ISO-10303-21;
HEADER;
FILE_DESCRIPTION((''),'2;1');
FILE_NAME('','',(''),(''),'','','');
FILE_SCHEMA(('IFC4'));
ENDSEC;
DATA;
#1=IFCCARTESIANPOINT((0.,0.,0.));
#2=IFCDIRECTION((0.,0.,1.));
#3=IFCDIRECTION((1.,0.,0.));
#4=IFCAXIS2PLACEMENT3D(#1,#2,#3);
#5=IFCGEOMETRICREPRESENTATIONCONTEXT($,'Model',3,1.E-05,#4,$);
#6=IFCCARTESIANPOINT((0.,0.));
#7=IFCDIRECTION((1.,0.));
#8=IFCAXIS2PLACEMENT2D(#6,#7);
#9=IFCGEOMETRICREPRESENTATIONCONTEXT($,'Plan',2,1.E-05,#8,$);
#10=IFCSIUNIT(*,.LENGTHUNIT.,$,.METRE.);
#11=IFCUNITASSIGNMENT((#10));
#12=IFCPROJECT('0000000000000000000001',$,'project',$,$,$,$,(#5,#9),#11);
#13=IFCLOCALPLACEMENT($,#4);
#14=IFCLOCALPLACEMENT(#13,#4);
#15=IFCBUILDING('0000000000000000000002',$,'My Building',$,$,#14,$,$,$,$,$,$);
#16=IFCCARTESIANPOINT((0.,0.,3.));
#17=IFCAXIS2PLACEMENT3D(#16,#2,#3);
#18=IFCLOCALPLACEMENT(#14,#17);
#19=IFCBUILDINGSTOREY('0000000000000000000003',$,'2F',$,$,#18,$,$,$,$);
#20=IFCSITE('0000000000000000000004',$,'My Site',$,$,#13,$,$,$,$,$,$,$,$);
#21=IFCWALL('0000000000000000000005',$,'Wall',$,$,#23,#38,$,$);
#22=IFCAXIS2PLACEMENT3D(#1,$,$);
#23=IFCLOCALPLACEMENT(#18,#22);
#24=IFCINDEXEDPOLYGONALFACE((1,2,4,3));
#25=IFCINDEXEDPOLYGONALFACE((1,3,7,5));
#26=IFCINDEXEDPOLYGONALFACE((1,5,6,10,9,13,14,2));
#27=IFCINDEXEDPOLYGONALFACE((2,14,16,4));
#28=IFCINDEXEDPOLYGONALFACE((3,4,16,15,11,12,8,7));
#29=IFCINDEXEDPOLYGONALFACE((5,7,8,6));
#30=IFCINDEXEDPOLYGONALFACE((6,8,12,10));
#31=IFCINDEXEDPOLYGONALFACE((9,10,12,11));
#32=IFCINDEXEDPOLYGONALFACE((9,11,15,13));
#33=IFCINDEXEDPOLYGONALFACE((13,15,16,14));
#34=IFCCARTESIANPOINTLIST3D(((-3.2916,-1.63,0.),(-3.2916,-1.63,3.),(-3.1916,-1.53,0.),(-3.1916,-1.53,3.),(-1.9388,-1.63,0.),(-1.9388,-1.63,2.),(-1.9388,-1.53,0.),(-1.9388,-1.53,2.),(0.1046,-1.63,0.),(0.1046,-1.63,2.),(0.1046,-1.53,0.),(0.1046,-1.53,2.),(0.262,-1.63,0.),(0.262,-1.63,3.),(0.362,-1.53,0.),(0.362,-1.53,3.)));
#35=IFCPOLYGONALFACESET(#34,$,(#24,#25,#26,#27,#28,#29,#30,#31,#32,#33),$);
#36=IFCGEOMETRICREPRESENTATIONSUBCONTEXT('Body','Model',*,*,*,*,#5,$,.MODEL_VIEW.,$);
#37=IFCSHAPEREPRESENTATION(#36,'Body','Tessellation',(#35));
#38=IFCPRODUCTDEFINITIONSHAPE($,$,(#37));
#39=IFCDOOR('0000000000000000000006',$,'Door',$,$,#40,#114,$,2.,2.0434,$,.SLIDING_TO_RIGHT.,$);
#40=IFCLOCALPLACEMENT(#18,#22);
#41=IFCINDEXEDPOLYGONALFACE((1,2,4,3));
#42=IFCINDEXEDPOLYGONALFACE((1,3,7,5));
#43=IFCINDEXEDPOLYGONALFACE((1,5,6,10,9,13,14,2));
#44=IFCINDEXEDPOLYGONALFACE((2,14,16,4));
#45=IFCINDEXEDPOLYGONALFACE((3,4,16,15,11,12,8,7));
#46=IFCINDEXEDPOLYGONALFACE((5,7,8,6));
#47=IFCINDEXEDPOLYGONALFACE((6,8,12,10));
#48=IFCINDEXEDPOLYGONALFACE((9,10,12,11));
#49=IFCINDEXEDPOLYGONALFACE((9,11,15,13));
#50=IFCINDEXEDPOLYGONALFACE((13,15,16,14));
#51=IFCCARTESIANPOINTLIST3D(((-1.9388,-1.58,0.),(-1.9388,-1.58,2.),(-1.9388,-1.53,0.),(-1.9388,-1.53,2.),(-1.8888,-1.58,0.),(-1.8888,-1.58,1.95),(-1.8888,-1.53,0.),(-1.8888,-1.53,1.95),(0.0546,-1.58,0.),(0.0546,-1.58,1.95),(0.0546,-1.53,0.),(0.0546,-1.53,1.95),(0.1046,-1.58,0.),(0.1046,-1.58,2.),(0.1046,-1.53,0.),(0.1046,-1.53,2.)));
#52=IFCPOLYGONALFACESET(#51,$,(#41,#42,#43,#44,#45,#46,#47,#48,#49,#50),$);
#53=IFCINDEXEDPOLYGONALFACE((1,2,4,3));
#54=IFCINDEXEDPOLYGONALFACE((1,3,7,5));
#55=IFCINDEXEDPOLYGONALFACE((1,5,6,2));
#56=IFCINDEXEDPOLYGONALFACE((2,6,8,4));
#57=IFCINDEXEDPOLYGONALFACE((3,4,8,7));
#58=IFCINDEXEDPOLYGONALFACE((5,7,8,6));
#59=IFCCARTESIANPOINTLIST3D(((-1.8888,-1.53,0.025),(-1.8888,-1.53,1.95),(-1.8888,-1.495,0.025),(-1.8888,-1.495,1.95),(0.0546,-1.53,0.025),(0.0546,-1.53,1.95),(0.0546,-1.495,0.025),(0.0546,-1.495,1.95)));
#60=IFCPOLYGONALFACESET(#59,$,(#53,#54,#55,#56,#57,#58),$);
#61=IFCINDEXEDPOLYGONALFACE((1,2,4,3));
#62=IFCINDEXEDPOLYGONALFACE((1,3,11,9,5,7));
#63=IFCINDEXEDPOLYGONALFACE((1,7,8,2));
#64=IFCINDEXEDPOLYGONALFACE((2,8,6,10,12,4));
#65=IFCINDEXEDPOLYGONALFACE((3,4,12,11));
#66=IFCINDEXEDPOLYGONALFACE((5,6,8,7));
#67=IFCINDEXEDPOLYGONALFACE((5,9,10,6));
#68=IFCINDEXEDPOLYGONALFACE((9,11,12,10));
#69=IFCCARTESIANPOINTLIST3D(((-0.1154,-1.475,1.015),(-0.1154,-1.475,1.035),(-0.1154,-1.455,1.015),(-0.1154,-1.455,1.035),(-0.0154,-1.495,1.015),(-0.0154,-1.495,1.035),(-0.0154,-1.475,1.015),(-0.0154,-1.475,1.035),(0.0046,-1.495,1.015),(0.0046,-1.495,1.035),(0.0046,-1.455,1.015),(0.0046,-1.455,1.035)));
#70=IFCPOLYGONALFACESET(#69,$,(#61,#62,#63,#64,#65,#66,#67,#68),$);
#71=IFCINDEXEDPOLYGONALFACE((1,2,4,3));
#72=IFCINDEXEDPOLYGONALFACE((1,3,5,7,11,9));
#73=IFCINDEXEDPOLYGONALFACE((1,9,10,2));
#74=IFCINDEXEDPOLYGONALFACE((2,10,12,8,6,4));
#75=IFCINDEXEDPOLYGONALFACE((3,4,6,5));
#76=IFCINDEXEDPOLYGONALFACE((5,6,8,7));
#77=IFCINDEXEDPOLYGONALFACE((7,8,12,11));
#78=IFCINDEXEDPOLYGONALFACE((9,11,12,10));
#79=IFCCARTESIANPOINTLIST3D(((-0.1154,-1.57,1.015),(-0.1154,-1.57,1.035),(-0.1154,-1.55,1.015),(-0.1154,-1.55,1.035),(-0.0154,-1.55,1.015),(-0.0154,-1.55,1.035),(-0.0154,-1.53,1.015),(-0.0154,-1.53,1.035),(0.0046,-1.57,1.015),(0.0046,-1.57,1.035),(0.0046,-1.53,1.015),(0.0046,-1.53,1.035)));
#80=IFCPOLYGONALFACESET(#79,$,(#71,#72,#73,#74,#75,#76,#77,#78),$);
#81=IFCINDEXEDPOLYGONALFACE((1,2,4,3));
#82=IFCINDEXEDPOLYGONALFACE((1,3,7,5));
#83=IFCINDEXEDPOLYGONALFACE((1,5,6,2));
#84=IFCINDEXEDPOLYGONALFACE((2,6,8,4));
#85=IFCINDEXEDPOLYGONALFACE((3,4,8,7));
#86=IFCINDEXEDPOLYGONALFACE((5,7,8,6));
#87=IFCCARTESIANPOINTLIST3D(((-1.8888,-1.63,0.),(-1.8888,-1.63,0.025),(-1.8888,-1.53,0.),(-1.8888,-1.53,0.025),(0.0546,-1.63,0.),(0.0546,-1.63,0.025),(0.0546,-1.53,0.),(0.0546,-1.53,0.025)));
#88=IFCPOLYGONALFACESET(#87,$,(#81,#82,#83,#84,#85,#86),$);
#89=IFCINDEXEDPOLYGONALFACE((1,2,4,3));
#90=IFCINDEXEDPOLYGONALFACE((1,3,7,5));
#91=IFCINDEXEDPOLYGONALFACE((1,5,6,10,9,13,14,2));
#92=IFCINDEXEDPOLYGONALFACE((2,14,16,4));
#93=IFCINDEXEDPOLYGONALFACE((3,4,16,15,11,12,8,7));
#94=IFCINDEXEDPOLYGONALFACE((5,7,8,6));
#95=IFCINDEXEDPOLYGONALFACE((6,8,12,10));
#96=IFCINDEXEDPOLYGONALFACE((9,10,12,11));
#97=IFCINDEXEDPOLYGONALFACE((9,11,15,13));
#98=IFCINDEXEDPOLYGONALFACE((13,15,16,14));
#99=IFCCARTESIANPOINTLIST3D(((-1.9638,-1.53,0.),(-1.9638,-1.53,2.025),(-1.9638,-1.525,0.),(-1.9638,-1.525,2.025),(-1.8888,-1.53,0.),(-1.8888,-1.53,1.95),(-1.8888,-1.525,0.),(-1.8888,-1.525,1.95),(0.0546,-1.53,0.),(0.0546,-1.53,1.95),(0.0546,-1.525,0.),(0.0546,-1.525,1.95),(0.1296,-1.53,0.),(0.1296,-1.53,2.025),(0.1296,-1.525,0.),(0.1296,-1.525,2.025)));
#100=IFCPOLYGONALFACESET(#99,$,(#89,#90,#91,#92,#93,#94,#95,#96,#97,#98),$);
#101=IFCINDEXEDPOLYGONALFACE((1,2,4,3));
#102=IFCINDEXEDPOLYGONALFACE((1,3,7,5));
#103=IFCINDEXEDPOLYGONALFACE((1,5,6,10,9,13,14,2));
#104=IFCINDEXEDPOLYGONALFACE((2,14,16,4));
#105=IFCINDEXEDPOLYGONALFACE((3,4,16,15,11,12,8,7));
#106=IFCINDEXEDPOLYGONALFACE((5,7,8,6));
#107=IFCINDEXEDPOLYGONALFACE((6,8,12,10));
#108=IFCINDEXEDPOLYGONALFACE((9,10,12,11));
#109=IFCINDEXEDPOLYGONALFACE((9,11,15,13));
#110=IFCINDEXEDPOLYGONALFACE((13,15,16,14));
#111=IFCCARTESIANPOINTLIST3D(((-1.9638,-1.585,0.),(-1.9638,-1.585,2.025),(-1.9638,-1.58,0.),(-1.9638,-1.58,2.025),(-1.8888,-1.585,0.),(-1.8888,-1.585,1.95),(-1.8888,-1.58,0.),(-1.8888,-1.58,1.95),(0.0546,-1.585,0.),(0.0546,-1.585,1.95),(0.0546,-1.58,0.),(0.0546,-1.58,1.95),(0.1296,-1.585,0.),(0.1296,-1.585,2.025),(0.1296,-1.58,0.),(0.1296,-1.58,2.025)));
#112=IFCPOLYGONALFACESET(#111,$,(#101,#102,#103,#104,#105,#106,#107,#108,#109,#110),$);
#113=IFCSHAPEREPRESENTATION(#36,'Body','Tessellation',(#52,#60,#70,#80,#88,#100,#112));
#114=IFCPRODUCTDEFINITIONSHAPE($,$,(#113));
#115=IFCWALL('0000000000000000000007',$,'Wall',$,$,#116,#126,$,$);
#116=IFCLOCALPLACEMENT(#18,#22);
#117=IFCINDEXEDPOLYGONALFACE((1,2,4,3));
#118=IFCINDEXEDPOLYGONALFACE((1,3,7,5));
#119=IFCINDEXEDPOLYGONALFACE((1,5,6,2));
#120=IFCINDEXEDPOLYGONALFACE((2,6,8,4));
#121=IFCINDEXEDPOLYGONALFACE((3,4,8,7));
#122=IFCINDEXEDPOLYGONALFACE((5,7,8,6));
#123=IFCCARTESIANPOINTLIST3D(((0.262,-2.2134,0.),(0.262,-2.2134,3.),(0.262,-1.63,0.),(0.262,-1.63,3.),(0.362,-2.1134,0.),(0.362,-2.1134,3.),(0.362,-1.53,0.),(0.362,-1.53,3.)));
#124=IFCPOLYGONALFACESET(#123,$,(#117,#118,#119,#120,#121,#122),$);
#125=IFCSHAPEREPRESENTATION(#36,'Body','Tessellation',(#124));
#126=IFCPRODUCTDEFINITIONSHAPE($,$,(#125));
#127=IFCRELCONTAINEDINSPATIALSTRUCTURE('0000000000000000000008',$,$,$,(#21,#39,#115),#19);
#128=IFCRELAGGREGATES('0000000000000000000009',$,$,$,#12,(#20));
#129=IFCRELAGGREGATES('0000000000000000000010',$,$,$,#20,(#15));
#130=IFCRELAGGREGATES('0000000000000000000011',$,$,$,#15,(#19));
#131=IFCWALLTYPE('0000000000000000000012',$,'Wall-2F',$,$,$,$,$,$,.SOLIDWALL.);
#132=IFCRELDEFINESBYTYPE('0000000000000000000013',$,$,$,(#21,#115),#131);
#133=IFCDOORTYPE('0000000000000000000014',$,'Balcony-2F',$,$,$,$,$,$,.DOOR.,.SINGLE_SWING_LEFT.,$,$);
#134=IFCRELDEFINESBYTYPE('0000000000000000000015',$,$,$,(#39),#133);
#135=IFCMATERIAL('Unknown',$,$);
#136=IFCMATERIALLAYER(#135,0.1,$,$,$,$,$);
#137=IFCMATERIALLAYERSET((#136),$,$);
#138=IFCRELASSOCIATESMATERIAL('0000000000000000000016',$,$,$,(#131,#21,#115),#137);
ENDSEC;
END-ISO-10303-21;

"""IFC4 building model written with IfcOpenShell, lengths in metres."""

from ifc_helpers import new_model, entity, si_unit, frame, origin_with_axes, origin_2d_with_axis, place, context, subcontext, project, spatial, line, indexed_curve, outline, extrude, shape, source, transform, mapped, material, layer, layer_set, layer_usage, type_object, type_shapes, element, fill, save


model = new_model("IFC4")

# Units and contexts
model_context = context("Model", 3, precision=1e-05, world=origin_with_axes())
plan_context = context("Plan", 2, precision=1e-05, world=origin_2d_with_axis())
body_context_1 = subcontext(model_context, "Body", "Model", "MODEL_VIEW")
body_context_2 = subcontext(plan_context, "Body", "Plan", "PLAN_VIEW")
ifc_project = project(units=[si_unit("LENGTHUNIT", "METRE")], contexts=[model_context, plan_context])

# Site, building, storey
site_placement = place(None, origin_with_axes())
site = spatial("IfcSite", under=ifc_project, at=site_placement, Name="My Site")
building_placement = place(site_placement, origin_with_axes())
building = spatial("IfcBuilding", under=site, at=building_placement, Name="My Building")
storey_placement = place(building_placement, frame((0.0, 0.0, 3.0), z_axis=(0.0, 0.0, 1.0), x_axis=(1.0, 0.0, 0.0)))
storey = spatial("IfcBuildingStorey", under=building, at=storey_placement, Name="2F")

# Shared definitions
ifc_material = material(Name="Unknown")

# Wall, opening, door
ifc_layer = layer(ifc_material, 0.1)
ifc_layer_set = layer_set([ifc_layer])
ifc_layer_usage_1 = layer_usage(ifc_layer_set, "AXIS2", "POSITIVE", 0.0)
wall_type = type_object("IfcWallType", Name="Wall-2F", PredefinedType="SOLIDWALL", material=ifc_layer_set)
wall_1_placement = place(storey_placement, frame((-3.2916, -1.63, 0.0), z_axis=(0.0, 0.0, 1.0), x_axis=(1.0, 0.0, 0.0)))
wall_1 = element("IfcWall", 1, at=wall_1_placement, inside=storey, type_object=wall_type, material=ifc_layer_usage_1, Name="Wall", context=body_context_1, shape_type="SweptSolid", body=[
    extrude(outline(indexed_curve([(0.0, 0.0), (0.1, 0.1), (3.6537, 0.1), (3.5537, 0.0)], segments=[line(1, 2, 3, 4, 1)])), origin_with_axes(), (0.0, 0.0, 1.0), 3.0),
])
shared_shape_1 = source(origin_with_axes(), body_context_1, "Body", "SweptSolid", [
    extrude(outline(indexed_curve([(0.0, 0.0), (2.0434, 0.0), (2.0434, 2.0), (0.0, 2.0)], segments=[line(1, 2, 3, 4, 1)])), frame((0.0, -0.6, 0.0), z_axis=(0.0, -1.0, 0.0), x_axis=(1.0, 0.0, 0.0)), (0.0, 0.0, -1.0), 1.2),
])
opening_1_placement = place(wall_1_placement, frame((3.3963, 0.1, 0.0), z_axis=(0.0, 0.0, 1.0), x_axis=(-1.0, 0.0, 0.0)))
opening_1 = element("IfcOpeningElement", 2, at=opening_1_placement, cuts=wall_1, PredefinedType="OPENING", context=body_context_1, shape_type="MappedRepresentation", body=[
    mapped(shared_shape_1, transform((0.0, 0.0, 0.0), x_axis=(1.0, 0.0, 0.0), y_axis=(0.0, 1.0, 0.0), z_axis=(0.0, 0.0, 1.0), scale=1.0)),
])
door_type_1 = type_object("IfcDoorType", Name="Balcony-2F", OperationType="SINGLE_SWING_LEFT", PredefinedType="DOOR")
shared_shape_2 = source(origin_with_axes(), body_context_1, "Body", "SweptSolid", [
    extrude(outline(indexed_curve([(0.0, 0.0), (0.0, 2.0), (2.0434, 2.0), (2.0434, 0.0), (1.9934, 0.0), (1.9934, 1.95), (0.05, 1.95), (0.05, 0.0)], segments=[line(1, 2, 3, 4, 5, 6, 7, 8, 1)])), frame((0.0, 0.0, 0.0), z_axis=(0.0, -1.0, 0.0), x_axis=(1.0, 0.0, 0.0)), (0.0, 0.0, -1.0), 0.05),
    extrude(outline(indexed_curve([(0.0, 0.0), (1.9434, 0.0), (1.9434, 0.035), (0.0, 0.035)], segments=[line(1, 2, 3, 4, 1)])), frame((0.05, -0.035, 0.025), z_axis=(0.0, 0.0, 1.0), x_axis=(1.0, 0.0, 0.0)), (0.0, 0.0, 1.0), 1.925),
    extrude(outline(indexed_curve([(0.0, 0.0), (0.0, -0.04), (0.12, -0.04), (0.12, -0.02), (0.02, -0.02), (0.02, 0.0)], segments=[line(1, 2, 3, 4, 5, 6, 1)])), frame((0.1, -0.035, 1.015), z_axis=(0.0, 0.0, 1.0), x_axis=(1.0, 0.0, 0.0)), (0.0, 0.0, 1.0), 0.02),
    extrude(outline(indexed_curve([(0.0, 0.0), (0.0, 0.04), (0.12, 0.04), (0.12, 0.02), (0.02, 0.02), (0.02, 0.0)], segments=[line(1, 2, 3, 4, 5, 6, 1)])), frame((0.1, 0.0, 1.015), z_axis=(0.0, 0.0, 1.0), x_axis=(1.0, 0.0, 0.0)), (0.0, 0.0, 1.0), 0.02),
    extrude(outline(indexed_curve([(0.0, 0.0), (1.9434, 0.0), (1.9434, 0.1), (0.0, 0.1)], segments=[line(1, 2, 3, 4, 1)])), frame((0.05, 0.0, 0.0), z_axis=(0.0, 0.0, 1.0), x_axis=(1.0, 0.0, 0.0)), (0.0, 0.0, 1.0), 0.025),
    extrude(outline(indexed_curve([(0.0, 0.0), (0.0, 2.025), (2.0934, 2.025), (2.0934, 0.0), (2.0184, 0.0), (2.0184, 1.95), (0.075, 1.95), (0.075, 0.0)], segments=[line(1, 2, 3, 4, 5, 6, 7, 8, 1)])), frame((-0.025, -0.005, 0.0), z_axis=(0.0, -1.0, 0.0), x_axis=(1.0, 0.0, 0.0)), (0.0, 0.0, -1.0), 0.005),
    extrude(outline(indexed_curve([(0.0, 0.0), (0.0, 2.025), (2.0934, 2.025), (2.0934, 0.0), (2.0184, 0.0), (2.0184, 1.95), (0.075, 1.95), (0.075, 0.0)], segments=[line(1, 2, 3, 4, 5, 6, 7, 8, 1)])), frame((-0.025, 0.05, 0.0), z_axis=(0.0, -1.0, 0.0), x_axis=(1.0, 0.0, 0.0)), (0.0, 0.0, -1.0), 0.005),
])
shared_shape_3 = source(origin_with_axes(), body_context_2, "Body", "Curve2D", [
    entity("IfcIndexedPolyCurve", entity("IfcCartesianPointList2D", [[0.0, 0.0], [0.05, 0.0], [0.05, 0.05], [0.0, 0.05]]), [entity("IfcLineIndex", [1, 2, 3, 4, 1])]),
    entity("IfcIndexedPolyCurve", entity("IfcCartesianPointList2D", [[2.0434, 0.0], [1.9934, 0.0], [1.9934, 0.05], [2.0434, 0.05]]), [entity("IfcLineIndex", [1, 2, 3, 4, 1])]),
    entity("IfcIndexedPolyCurve", entity("IfcCartesianPointList2D", [[2.965, -0.035], [1.0217, -0.035], [1.0217, 0.0], [2.965, 0.0]]), [entity("IfcLineIndex", [1, 2, 3, 4, 1])]),
])
type_shapes(door_type_1, [shared_shape_2, shared_shape_3])
door_1_placement = place(opening_1_placement, frame((0.0, 0.0, 0.0), z_axis=(0.0, 0.0, 1.0), x_axis=(1.0, 0.0, 0.0)))
door_1 = element("IfcDoor", 3, at=door_1_placement, inside=storey, type_object=door_type_1, Name="Door", OperationType="SLIDING_TO_RIGHT", OverallHeight=2.0, OverallWidth=2.0434, shapes=[
    shape(body_context_1, "Body", "MappedRepresentation", [mapped(shared_shape_2, transform((0.0, 0.0, 0.0), x_axis=(1.0, 0.0, 0.0), y_axis=(0.0, 1.0, 0.0), z_axis=(0.0, 0.0, 1.0), scale=1.0))]),
    shape(body_context_2, "Body", "MappedRepresentation", [mapped(shared_shape_3, transform((0.0, 0.0, 0.0), x_axis=(1.0, 0.0, 0.0), y_axis=(0.0, 1.0, 0.0), z_axis=(0.0, 0.0, 1.0), scale=1.0))]),
])
fill(opening_1, door_1)

# Wall
ifc_layer_usage_2 = layer_usage(ifc_layer_set, "AXIS2", "POSITIVE", 0.0)
wall_2_placement = place(storey_placement, frame((0.262, -1.63, 0.0), z_axis=(0.0, 0.0, 1.0), x_axis=(0.000001, -1.0, 0.0)))
element("IfcWall", 4, at=wall_2_placement, inside=storey, type_object=wall_type, material=ifc_layer_usage_2, Name="Wall", context=body_context_1, shape_type="SweptSolid", body=[
    extrude(outline(indexed_curve([(0.0, 0.0), (-0.1, 0.1), (0.4834, 0.1), (0.5834, 0.0)], segments=[line(1, 2, 3, 4, 1)])), origin_with_axes(), (0.0, 0.0, 1.0), 3.0),
])

save(model, "model.ifc")
